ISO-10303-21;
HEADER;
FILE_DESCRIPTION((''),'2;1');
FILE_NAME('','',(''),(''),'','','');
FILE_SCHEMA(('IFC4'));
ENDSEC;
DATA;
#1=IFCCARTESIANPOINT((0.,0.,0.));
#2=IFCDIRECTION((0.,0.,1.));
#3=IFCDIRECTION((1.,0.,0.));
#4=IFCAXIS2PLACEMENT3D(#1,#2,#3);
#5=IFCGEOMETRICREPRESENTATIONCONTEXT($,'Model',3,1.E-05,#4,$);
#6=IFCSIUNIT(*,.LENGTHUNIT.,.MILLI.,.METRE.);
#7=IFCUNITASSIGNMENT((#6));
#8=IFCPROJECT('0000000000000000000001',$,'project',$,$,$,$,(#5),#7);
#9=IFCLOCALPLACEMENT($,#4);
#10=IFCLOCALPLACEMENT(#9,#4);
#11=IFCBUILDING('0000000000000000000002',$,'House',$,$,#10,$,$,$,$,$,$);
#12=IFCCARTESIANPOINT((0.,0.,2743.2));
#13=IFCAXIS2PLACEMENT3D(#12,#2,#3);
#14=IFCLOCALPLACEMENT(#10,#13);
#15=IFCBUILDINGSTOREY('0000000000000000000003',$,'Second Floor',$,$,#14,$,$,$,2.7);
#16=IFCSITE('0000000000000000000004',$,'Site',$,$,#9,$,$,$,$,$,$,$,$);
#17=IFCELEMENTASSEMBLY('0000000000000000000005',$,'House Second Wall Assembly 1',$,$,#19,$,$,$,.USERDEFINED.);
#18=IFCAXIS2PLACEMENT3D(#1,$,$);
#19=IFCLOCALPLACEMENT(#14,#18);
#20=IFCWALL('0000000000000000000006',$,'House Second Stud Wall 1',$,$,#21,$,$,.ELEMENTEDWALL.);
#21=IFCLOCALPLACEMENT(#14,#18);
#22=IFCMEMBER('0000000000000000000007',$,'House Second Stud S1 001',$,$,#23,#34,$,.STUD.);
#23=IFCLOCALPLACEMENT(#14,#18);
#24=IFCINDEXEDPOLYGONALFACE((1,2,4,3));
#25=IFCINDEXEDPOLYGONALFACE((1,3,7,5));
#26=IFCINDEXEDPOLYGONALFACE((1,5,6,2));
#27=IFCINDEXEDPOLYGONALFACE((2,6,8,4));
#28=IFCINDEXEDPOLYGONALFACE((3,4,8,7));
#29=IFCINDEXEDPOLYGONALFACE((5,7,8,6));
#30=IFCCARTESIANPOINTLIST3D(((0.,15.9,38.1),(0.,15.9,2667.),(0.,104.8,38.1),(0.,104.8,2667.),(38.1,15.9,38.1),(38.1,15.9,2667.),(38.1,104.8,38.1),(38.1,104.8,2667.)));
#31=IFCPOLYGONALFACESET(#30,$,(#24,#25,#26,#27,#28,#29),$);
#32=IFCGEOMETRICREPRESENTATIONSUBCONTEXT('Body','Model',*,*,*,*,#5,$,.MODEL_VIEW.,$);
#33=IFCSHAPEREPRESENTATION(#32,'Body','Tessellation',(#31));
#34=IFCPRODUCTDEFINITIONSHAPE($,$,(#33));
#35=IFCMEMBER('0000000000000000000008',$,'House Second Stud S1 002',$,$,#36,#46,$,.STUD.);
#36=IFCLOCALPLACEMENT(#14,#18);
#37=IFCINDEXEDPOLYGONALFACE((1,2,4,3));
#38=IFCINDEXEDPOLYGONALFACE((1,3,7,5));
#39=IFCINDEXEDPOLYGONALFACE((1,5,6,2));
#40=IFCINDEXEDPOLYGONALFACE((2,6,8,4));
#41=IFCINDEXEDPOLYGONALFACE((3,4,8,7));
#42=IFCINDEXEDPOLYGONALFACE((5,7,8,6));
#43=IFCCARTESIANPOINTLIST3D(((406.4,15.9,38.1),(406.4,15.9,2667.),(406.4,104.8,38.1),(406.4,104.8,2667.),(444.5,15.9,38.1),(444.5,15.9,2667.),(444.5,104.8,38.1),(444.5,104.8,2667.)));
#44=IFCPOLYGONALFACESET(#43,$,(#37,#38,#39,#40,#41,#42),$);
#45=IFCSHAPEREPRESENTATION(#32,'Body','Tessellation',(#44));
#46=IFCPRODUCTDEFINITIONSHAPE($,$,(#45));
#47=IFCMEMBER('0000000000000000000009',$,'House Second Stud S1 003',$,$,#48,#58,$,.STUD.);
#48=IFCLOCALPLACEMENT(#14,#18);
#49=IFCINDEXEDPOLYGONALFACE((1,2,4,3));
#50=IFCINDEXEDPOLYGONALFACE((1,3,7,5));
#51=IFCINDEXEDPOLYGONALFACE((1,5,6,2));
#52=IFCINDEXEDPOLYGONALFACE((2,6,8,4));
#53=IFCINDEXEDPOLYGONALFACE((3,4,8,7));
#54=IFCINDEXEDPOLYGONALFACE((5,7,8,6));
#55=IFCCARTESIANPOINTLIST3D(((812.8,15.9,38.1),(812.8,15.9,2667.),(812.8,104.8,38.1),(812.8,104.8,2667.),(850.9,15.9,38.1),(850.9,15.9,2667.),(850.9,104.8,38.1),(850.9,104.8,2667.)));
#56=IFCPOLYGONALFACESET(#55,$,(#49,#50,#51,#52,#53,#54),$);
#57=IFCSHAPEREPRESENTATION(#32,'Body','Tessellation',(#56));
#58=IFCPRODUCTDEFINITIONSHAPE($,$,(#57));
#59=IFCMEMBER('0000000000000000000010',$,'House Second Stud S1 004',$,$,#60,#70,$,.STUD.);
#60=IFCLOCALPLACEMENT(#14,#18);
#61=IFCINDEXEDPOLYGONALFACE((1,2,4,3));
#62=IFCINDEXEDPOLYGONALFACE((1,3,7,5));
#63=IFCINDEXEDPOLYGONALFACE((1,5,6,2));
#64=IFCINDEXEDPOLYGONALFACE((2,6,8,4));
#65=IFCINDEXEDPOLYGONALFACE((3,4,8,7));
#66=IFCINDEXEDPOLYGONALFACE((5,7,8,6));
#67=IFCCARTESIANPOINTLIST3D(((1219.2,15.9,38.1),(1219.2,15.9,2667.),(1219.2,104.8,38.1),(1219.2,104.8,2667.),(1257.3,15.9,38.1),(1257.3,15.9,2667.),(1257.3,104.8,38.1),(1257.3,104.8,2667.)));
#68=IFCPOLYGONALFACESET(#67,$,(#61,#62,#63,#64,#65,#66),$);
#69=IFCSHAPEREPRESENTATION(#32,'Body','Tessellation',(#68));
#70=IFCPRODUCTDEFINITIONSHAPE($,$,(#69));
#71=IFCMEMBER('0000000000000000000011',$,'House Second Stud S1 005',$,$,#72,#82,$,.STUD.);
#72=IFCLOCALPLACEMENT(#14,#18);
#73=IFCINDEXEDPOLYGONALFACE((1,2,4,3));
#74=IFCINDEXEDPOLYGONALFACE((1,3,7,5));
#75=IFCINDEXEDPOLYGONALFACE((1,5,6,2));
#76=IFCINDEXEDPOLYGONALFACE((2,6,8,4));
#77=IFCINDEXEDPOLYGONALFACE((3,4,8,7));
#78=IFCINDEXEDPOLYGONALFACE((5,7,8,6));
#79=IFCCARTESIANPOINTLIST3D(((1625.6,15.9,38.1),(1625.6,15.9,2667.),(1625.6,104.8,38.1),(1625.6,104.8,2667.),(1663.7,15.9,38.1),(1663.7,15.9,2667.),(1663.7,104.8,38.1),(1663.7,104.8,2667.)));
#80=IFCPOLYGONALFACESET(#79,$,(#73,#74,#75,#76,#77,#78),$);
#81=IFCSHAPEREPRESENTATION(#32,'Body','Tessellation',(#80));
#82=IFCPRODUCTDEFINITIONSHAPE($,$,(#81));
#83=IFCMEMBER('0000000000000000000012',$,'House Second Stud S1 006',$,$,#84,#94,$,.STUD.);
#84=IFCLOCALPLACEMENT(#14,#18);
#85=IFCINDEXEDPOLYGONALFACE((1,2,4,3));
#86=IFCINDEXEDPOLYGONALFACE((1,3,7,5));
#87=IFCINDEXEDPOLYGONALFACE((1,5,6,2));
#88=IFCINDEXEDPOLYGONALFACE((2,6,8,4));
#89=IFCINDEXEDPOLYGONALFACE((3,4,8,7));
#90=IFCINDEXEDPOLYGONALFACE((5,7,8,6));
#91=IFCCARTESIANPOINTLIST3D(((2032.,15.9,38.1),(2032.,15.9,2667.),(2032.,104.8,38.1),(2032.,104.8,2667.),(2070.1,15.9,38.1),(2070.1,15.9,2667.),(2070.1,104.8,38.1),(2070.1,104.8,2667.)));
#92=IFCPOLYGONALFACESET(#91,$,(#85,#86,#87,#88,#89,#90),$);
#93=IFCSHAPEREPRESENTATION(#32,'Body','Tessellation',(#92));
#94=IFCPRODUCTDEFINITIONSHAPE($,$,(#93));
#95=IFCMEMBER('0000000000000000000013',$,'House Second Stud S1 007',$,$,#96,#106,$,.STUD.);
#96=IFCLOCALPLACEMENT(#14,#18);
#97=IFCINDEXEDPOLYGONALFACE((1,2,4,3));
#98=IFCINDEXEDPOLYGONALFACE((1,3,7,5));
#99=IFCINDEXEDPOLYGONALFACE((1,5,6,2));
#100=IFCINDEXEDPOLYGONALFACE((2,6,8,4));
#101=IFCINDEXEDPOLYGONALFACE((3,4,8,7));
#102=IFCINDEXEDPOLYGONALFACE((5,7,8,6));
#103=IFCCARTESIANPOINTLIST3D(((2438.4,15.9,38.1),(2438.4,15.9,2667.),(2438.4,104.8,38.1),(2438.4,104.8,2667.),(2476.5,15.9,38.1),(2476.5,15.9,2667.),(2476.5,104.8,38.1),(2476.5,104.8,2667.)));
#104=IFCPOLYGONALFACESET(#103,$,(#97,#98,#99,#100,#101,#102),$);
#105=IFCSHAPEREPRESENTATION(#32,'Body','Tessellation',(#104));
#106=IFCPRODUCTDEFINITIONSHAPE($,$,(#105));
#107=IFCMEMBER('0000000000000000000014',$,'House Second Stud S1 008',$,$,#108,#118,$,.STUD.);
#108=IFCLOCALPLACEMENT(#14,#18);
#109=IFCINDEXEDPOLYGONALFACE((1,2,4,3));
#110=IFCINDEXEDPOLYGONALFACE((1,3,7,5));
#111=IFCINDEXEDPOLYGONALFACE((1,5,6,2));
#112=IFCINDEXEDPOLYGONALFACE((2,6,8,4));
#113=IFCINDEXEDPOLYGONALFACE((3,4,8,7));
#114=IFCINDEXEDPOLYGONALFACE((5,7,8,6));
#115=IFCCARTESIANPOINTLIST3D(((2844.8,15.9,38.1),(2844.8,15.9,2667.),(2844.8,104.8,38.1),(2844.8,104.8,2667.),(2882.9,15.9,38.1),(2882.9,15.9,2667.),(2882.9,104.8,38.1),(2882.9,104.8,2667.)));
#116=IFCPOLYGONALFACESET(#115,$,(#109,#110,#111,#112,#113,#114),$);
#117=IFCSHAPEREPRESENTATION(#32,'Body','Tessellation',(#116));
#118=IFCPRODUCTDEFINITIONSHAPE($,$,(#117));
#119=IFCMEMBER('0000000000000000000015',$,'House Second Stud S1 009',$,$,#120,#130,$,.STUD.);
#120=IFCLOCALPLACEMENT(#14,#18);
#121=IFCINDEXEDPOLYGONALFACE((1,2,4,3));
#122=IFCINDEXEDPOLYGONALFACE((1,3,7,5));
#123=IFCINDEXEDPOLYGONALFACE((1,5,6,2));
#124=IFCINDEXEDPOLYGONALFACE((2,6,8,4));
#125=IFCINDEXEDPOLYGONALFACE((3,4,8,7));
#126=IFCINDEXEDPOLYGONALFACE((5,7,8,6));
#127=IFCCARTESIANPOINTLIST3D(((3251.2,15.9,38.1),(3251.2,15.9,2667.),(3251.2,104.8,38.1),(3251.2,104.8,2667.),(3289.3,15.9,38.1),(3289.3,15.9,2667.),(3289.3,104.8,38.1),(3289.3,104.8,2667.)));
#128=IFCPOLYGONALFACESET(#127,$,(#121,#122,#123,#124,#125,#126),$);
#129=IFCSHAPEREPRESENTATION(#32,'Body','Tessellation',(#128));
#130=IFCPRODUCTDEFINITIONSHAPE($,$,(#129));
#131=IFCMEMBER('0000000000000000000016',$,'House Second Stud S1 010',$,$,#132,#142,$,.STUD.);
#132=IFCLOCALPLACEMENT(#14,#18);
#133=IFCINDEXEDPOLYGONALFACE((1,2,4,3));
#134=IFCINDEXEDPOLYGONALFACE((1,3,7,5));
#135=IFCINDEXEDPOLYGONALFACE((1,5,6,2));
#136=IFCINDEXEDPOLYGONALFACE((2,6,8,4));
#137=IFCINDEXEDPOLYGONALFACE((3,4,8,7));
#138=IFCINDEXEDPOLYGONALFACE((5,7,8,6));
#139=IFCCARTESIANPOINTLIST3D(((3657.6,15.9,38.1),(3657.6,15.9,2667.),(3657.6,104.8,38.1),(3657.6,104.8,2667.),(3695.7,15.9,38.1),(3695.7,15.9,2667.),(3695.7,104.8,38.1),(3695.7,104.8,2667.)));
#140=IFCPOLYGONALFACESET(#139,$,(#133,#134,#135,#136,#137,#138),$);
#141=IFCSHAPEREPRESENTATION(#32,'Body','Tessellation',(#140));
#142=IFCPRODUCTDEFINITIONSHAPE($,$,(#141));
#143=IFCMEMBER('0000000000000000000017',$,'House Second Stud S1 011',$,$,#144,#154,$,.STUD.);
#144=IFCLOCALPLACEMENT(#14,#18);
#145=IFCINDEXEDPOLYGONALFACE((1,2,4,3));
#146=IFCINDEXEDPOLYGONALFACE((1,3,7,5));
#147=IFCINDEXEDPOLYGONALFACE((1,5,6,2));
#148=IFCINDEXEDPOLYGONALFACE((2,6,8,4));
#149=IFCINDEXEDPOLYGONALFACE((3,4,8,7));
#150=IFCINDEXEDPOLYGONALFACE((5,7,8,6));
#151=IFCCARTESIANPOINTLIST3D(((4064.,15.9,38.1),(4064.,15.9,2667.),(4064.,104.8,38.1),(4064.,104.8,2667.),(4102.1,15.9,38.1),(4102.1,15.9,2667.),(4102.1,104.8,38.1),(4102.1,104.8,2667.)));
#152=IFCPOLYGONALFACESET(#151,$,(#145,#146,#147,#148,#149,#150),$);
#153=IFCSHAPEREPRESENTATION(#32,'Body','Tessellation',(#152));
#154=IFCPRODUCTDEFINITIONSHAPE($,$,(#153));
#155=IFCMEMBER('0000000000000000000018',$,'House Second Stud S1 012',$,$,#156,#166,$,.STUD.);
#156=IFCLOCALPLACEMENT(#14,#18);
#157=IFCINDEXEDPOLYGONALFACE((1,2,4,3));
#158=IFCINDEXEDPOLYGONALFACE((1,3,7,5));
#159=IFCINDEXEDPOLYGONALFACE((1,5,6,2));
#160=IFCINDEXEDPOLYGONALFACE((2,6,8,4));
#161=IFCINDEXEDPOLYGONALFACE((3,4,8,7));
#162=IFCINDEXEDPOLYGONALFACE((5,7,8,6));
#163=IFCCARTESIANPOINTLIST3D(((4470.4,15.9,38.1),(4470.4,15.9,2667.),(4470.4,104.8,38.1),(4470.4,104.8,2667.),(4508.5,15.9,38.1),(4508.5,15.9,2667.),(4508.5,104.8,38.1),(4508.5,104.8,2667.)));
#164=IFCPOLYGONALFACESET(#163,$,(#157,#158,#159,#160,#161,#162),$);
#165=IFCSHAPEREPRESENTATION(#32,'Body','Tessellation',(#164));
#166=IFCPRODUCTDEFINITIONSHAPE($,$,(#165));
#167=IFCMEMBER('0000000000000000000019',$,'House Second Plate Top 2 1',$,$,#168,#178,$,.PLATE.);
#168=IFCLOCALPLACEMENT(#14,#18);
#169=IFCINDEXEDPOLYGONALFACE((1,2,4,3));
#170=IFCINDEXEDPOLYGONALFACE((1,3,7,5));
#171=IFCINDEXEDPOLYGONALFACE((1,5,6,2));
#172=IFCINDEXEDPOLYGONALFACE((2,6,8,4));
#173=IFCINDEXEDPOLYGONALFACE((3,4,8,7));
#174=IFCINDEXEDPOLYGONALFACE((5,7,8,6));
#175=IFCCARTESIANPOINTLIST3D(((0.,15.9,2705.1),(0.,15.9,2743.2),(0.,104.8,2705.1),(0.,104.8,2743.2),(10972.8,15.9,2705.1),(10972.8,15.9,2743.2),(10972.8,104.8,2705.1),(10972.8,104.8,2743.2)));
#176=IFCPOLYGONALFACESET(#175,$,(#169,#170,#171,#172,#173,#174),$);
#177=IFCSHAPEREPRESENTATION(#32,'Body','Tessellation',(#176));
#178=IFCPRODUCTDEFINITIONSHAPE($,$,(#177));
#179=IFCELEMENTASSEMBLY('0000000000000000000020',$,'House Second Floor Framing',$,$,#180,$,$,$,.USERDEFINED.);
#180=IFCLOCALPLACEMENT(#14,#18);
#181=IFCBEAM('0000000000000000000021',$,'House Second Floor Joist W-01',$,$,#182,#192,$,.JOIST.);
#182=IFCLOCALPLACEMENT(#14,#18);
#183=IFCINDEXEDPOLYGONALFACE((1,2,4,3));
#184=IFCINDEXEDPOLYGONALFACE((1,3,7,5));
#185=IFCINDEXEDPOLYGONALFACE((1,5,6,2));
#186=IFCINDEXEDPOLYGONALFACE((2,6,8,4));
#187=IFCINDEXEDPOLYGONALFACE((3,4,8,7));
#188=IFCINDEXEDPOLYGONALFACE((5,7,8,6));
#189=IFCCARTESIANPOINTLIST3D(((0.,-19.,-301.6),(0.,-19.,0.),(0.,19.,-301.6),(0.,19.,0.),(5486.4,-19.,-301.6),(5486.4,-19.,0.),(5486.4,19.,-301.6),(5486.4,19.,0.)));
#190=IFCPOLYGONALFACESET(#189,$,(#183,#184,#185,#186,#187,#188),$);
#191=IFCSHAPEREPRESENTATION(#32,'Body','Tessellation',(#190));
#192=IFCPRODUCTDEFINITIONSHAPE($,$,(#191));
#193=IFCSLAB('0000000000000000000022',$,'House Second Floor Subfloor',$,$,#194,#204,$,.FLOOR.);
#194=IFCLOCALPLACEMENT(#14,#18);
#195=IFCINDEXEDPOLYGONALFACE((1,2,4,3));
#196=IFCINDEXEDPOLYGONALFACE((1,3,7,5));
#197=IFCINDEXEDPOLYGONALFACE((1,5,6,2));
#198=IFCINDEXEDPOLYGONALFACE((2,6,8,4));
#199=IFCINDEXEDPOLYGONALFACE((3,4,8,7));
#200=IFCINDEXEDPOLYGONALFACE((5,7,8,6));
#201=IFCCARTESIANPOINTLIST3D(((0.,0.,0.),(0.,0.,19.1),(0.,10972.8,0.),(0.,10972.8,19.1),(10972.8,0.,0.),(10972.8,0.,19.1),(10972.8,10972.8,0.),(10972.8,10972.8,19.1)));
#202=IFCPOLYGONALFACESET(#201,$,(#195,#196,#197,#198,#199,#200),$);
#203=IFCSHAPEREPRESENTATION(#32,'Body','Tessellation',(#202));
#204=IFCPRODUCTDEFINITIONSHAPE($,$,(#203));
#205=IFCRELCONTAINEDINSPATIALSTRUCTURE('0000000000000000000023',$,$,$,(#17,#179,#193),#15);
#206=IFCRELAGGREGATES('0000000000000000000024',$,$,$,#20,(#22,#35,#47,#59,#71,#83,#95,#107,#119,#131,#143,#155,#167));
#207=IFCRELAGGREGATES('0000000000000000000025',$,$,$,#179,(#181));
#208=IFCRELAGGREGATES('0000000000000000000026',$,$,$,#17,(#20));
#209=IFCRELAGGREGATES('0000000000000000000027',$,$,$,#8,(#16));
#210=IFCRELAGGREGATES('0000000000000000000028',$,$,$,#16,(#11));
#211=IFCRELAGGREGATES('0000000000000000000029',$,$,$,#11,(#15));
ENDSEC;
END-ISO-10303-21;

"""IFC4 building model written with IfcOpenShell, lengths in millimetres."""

from ifc_helpers import new_model, si_unit, frame, origin_with_axes, origin_2d, place, context, subcontext, project, spatial, indexed_curve, rectangle, outline, extrude, element, aggregate, save


model = new_model("IFC4")

# Units and contexts
model_context = context("Model", 3, precision=1e-05, world=origin_with_axes())
body_context = subcontext(model_context, "Body", "Model", "MODEL_VIEW")
ifc_project = project(units=[si_unit("LENGTHUNIT", "METRE", prefix="MILLI")], contexts=[model_context])

# Site, building, storey
site_placement = place(None, origin_with_axes())
site = spatial("IfcSite", under=ifc_project, at=site_placement, Name="Site")
building_placement = place(site_placement, origin_with_axes())
building = spatial("IfcBuilding", under=site, at=building_placement, Name="House")
storey_placement = place(building_placement, frame((0.0, 0.0, 2743.2), z_axis=(0.0, 0.0, 1.0), x_axis=(1.0, 0.0, 0.0)))
storey = spatial("IfcBuildingStorey", under=building, at=storey_placement, Name="Second Floor", Elevation=2.7)

# Element assembly, wall, members
assembly_1_placement = place(storey_placement, frame((0.0, 0.0, -2743.2), z_axis=(0.0, 0.0, 1.0), x_axis=(1.0, 0.0, 0.0)))
assembly_1 = element("IfcElementAssembly", 1, at=assembly_1_placement, inside=storey, Name="House Second Wall Assembly 1", PredefinedType="USERDEFINED")
wall_1_placement = place(assembly_1_placement, frame((0.0, 0.0, 2743.2), z_axis=(0.0, 0.0, 1.0), x_axis=(1.0, 0.0, 0.0)))
wall_1 = element("IfcWall", 2, at=wall_1_placement, Name="House Second Stud Wall 1", PredefinedType="ELEMENTEDWALL")
member_1_placement = place(wall_1_placement, frame((19.1, 60.3, 38.1), z_axis=(0.0, 0.0, 1.0), x_axis=(1.0, 0.0, 0.0)))
member_1 = element("IfcMember", 3, at=member_1_placement, Name="House Second Stud S1 001", PredefinedType="STUD", context=body_context, shape_type="SweptSolid", body=[
    extrude(rectangle(XDim=38.1, YDim=88.9, at=origin_2d()), origin_with_axes(), (0.0, 0.0, 1.0), 2628.9),
])
member_2_placement = place(wall_1_placement, frame((425.4, 60.3, 38.1), z_axis=(0.0, 0.0, 1.0), x_axis=(1.0, 0.0, 0.0)))
member_2 = element("IfcMember", 4, at=member_2_placement, Name="House Second Stud S1 002", PredefinedType="STUD", context=body_context, shape_type="SweptSolid", body=[
    extrude(rectangle(XDim=38.1, YDim=88.9, at=origin_2d()), origin_with_axes(), (0.0, 0.0, 1.0), 2628.9),
])
member_3_placement = place(wall_1_placement, frame((831.9, 60.3, 38.1), z_axis=(0.0, 0.0, 1.0), x_axis=(1.0, 0.0, 0.0)))
member_3 = element("IfcMember", 5, at=member_3_placement, Name="House Second Stud S1 003", PredefinedType="STUD", context=body_context, shape_type="SweptSolid", body=[
    extrude(rectangle(XDim=38.1, YDim=88.9, at=origin_2d()), origin_with_axes(), (0.0, 0.0, 1.0), 2628.9),
])
member_4_placement = place(wall_1_placement, frame((1238.2, 60.3, 38.1), z_axis=(0.0, 0.0, 1.0), x_axis=(1.0, 0.0, 0.0)))
member_4 = element("IfcMember", 6, at=member_4_placement, Name="House Second Stud S1 004", PredefinedType="STUD", context=body_context, shape_type="SweptSolid", body=[
    extrude(rectangle(XDim=38.1, YDim=88.9, at=origin_2d()), origin_with_axes(), (0.0, 0.0, 1.0), 2628.9),
])
member_5_placement = place(wall_1_placement, frame((1644.7, 60.3, 38.1), z_axis=(0.0, 0.0, 1.0), x_axis=(1.0, 0.0, 0.0)))
member_5 = element("IfcMember", 7, at=member_5_placement, Name="House Second Stud S1 005", PredefinedType="STUD", context=body_context, shape_type="SweptSolid", body=[
    extrude(rectangle(XDim=38.1, YDim=88.9, at=origin_2d()), origin_with_axes(), (0.0, 0.0, 1.0), 2628.9),
])
member_6_placement = place(wall_1_placement, frame((2051.1, 60.3, 38.1), z_axis=(0.0, 0.0, 1.0), x_axis=(1.0, 0.0, 0.0)))
member_6 = element("IfcMember", 8, at=member_6_placement, Name="House Second Stud S1 006", PredefinedType="STUD", context=body_context, shape_type="SweptSolid", body=[
    extrude(rectangle(XDim=38.1, YDim=88.9, at=origin_2d()), origin_with_axes(), (0.0, 0.0, 1.0), 2628.9),
])
member_7_placement = place(wall_1_placement, frame((2457.4, 60.3, 38.1), z_axis=(0.0, 0.0, 1.0), x_axis=(1.0, 0.0, 0.0)))
member_7 = element("IfcMember", 9, at=member_7_placement, Name="House Second Stud S1 007", PredefinedType="STUD", context=body_context, shape_type="SweptSolid", body=[
    extrude(rectangle(XDim=38.1, YDim=88.9, at=origin_2d()), origin_with_axes(), (0.0, 0.0, 1.0), 2628.9),
])
member_8_placement = place(wall_1_placement, frame((2863.8, 60.3, 38.1), z_axis=(0.0, 0.0, 1.0), x_axis=(1.0, 0.0, 0.0)))
member_8 = element("IfcMember", 10, at=member_8_placement, Name="House Second Stud S1 008", PredefinedType="STUD", context=body_context, shape_type="SweptSolid", body=[
    extrude(rectangle(XDim=38.1, YDim=88.9, at=origin_2d()), origin_with_axes(), (0.0, 0.0, 1.0), 2628.9),
])
member_9_placement = place(wall_1_placement, frame((3270.2, 60.3, 38.1), z_axis=(0.0, 0.0, 1.0), x_axis=(1.0, 0.0, 0.0)))
member_9 = element("IfcMember", 11, at=member_9_placement, Name="House Second Stud S1 009", PredefinedType="STUD", context=body_context, shape_type="SweptSolid", body=[
    extrude(rectangle(XDim=38.1, YDim=88.9, at=origin_2d()), origin_with_axes(), (0.0, 0.0, 1.0), 2628.9),
])
member_10_placement = place(wall_1_placement, frame((3676.7, 60.3, 38.1), z_axis=(0.0, 0.0, 1.0), x_axis=(1.0, 0.0, 0.0)))
member_10 = element("IfcMember", 12, at=member_10_placement, Name="House Second Stud S1 010", PredefinedType="STUD", context=body_context, shape_type="SweptSolid", body=[
    extrude(rectangle(XDim=38.1, YDim=88.9, at=origin_2d()), origin_with_axes(), (0.0, 0.0, 1.0), 2628.9),
])
member_11_placement = place(wall_1_placement, frame((4083.1, 60.3, 38.1), z_axis=(0.0, 0.0, 1.0), x_axis=(1.0, 0.0, 0.0)))
member_11 = element("IfcMember", 13, at=member_11_placement, Name="House Second Stud S1 011", PredefinedType="STUD", context=body_context, shape_type="SweptSolid", body=[
    extrude(rectangle(XDim=38.1, YDim=88.9, at=origin_2d()), origin_with_axes(), (0.0, 0.0, 1.0), 2628.9),
])
member_12_placement = place(wall_1_placement, frame((4489.4, 60.3, 38.1), z_axis=(0.0, 0.0, 1.0), x_axis=(1.0, 0.0, 0.0)))
member_12 = element("IfcMember", 14, at=member_12_placement, Name="House Second Stud S1 012", PredefinedType="STUD", context=body_context, shape_type="SweptSolid", body=[
    extrude(rectangle(XDim=38.1, YDim=88.9, at=origin_2d()), origin_with_axes(), (0.0, 0.0, 1.0), 2628.9),
])
member_13_placement = place(wall_1_placement, frame((0.0, 60.3, 2724.2), z_axis=(1.0, 0.0, 0.0), x_axis=(0.0, 0.0, 1.0)))
member_13 = element("IfcMember", 15, at=member_13_placement, Name="House Second Plate Top 2 1", PredefinedType="PLATE", context=body_context, shape_type="SweptSolid", body=[
    extrude(rectangle(XDim=38.1, YDim=88.9, at=origin_2d()), origin_with_axes(), (0.0, 0.0, 1.0), 10972.8),
])
aggregate(wall_1, [member_1, member_2, member_3, member_4, member_5, member_6, member_7, member_8, member_9, member_10, member_11, member_12, member_13])

# Element assembly, beam
assembly_2_placement = place(storey_placement, frame((0.0, 0.0, -2743.2), z_axis=(0.0, 0.0, 1.0), x_axis=(1.0, 0.0, 0.0)))
assembly_2 = element("IfcElementAssembly", 16, at=assembly_2_placement, inside=storey, Name="House Second Floor Framing", PredefinedType="USERDEFINED")
beam_placement = place(assembly_2_placement, frame((0.0, 0.0, 2592.4), z_axis=(1.0, 0.0, 0.0), x_axis=(0.0, 1.0, 0.0)))
beam = element("IfcBeam", 17, at=beam_placement, Name="House Second Floor Joist W-01", PredefinedType="JOIST", context=body_context, shape_type="SweptSolid", body=[
    extrude(rectangle(XDim=38.1, YDim=301.6, at=origin_2d()), origin_with_axes(), (0.0, 0.0, 1.0), 5486.4),
])
aggregate(assembly_2, [beam])

# Slab
slab_1_placement = place(storey_placement, origin_with_axes())
element("IfcSlab", 18, at=slab_1_placement, inside=storey, Name="House Second Floor Subfloor", PredefinedType="FLOOR", context=body_context, shape_type="SweptSolid", body=[
    extrude(outline(indexed_curve([(0.0, 0.0), (10972.8, 0.0), (10972.8, 10972.8), (0.0, 10972.8), (0.0, 0.0)])), None, (0.0, 0.0, 1.0), 19.1),
])

aggregate(assembly_1, [wall_1])

save(model, "model.ifc")
